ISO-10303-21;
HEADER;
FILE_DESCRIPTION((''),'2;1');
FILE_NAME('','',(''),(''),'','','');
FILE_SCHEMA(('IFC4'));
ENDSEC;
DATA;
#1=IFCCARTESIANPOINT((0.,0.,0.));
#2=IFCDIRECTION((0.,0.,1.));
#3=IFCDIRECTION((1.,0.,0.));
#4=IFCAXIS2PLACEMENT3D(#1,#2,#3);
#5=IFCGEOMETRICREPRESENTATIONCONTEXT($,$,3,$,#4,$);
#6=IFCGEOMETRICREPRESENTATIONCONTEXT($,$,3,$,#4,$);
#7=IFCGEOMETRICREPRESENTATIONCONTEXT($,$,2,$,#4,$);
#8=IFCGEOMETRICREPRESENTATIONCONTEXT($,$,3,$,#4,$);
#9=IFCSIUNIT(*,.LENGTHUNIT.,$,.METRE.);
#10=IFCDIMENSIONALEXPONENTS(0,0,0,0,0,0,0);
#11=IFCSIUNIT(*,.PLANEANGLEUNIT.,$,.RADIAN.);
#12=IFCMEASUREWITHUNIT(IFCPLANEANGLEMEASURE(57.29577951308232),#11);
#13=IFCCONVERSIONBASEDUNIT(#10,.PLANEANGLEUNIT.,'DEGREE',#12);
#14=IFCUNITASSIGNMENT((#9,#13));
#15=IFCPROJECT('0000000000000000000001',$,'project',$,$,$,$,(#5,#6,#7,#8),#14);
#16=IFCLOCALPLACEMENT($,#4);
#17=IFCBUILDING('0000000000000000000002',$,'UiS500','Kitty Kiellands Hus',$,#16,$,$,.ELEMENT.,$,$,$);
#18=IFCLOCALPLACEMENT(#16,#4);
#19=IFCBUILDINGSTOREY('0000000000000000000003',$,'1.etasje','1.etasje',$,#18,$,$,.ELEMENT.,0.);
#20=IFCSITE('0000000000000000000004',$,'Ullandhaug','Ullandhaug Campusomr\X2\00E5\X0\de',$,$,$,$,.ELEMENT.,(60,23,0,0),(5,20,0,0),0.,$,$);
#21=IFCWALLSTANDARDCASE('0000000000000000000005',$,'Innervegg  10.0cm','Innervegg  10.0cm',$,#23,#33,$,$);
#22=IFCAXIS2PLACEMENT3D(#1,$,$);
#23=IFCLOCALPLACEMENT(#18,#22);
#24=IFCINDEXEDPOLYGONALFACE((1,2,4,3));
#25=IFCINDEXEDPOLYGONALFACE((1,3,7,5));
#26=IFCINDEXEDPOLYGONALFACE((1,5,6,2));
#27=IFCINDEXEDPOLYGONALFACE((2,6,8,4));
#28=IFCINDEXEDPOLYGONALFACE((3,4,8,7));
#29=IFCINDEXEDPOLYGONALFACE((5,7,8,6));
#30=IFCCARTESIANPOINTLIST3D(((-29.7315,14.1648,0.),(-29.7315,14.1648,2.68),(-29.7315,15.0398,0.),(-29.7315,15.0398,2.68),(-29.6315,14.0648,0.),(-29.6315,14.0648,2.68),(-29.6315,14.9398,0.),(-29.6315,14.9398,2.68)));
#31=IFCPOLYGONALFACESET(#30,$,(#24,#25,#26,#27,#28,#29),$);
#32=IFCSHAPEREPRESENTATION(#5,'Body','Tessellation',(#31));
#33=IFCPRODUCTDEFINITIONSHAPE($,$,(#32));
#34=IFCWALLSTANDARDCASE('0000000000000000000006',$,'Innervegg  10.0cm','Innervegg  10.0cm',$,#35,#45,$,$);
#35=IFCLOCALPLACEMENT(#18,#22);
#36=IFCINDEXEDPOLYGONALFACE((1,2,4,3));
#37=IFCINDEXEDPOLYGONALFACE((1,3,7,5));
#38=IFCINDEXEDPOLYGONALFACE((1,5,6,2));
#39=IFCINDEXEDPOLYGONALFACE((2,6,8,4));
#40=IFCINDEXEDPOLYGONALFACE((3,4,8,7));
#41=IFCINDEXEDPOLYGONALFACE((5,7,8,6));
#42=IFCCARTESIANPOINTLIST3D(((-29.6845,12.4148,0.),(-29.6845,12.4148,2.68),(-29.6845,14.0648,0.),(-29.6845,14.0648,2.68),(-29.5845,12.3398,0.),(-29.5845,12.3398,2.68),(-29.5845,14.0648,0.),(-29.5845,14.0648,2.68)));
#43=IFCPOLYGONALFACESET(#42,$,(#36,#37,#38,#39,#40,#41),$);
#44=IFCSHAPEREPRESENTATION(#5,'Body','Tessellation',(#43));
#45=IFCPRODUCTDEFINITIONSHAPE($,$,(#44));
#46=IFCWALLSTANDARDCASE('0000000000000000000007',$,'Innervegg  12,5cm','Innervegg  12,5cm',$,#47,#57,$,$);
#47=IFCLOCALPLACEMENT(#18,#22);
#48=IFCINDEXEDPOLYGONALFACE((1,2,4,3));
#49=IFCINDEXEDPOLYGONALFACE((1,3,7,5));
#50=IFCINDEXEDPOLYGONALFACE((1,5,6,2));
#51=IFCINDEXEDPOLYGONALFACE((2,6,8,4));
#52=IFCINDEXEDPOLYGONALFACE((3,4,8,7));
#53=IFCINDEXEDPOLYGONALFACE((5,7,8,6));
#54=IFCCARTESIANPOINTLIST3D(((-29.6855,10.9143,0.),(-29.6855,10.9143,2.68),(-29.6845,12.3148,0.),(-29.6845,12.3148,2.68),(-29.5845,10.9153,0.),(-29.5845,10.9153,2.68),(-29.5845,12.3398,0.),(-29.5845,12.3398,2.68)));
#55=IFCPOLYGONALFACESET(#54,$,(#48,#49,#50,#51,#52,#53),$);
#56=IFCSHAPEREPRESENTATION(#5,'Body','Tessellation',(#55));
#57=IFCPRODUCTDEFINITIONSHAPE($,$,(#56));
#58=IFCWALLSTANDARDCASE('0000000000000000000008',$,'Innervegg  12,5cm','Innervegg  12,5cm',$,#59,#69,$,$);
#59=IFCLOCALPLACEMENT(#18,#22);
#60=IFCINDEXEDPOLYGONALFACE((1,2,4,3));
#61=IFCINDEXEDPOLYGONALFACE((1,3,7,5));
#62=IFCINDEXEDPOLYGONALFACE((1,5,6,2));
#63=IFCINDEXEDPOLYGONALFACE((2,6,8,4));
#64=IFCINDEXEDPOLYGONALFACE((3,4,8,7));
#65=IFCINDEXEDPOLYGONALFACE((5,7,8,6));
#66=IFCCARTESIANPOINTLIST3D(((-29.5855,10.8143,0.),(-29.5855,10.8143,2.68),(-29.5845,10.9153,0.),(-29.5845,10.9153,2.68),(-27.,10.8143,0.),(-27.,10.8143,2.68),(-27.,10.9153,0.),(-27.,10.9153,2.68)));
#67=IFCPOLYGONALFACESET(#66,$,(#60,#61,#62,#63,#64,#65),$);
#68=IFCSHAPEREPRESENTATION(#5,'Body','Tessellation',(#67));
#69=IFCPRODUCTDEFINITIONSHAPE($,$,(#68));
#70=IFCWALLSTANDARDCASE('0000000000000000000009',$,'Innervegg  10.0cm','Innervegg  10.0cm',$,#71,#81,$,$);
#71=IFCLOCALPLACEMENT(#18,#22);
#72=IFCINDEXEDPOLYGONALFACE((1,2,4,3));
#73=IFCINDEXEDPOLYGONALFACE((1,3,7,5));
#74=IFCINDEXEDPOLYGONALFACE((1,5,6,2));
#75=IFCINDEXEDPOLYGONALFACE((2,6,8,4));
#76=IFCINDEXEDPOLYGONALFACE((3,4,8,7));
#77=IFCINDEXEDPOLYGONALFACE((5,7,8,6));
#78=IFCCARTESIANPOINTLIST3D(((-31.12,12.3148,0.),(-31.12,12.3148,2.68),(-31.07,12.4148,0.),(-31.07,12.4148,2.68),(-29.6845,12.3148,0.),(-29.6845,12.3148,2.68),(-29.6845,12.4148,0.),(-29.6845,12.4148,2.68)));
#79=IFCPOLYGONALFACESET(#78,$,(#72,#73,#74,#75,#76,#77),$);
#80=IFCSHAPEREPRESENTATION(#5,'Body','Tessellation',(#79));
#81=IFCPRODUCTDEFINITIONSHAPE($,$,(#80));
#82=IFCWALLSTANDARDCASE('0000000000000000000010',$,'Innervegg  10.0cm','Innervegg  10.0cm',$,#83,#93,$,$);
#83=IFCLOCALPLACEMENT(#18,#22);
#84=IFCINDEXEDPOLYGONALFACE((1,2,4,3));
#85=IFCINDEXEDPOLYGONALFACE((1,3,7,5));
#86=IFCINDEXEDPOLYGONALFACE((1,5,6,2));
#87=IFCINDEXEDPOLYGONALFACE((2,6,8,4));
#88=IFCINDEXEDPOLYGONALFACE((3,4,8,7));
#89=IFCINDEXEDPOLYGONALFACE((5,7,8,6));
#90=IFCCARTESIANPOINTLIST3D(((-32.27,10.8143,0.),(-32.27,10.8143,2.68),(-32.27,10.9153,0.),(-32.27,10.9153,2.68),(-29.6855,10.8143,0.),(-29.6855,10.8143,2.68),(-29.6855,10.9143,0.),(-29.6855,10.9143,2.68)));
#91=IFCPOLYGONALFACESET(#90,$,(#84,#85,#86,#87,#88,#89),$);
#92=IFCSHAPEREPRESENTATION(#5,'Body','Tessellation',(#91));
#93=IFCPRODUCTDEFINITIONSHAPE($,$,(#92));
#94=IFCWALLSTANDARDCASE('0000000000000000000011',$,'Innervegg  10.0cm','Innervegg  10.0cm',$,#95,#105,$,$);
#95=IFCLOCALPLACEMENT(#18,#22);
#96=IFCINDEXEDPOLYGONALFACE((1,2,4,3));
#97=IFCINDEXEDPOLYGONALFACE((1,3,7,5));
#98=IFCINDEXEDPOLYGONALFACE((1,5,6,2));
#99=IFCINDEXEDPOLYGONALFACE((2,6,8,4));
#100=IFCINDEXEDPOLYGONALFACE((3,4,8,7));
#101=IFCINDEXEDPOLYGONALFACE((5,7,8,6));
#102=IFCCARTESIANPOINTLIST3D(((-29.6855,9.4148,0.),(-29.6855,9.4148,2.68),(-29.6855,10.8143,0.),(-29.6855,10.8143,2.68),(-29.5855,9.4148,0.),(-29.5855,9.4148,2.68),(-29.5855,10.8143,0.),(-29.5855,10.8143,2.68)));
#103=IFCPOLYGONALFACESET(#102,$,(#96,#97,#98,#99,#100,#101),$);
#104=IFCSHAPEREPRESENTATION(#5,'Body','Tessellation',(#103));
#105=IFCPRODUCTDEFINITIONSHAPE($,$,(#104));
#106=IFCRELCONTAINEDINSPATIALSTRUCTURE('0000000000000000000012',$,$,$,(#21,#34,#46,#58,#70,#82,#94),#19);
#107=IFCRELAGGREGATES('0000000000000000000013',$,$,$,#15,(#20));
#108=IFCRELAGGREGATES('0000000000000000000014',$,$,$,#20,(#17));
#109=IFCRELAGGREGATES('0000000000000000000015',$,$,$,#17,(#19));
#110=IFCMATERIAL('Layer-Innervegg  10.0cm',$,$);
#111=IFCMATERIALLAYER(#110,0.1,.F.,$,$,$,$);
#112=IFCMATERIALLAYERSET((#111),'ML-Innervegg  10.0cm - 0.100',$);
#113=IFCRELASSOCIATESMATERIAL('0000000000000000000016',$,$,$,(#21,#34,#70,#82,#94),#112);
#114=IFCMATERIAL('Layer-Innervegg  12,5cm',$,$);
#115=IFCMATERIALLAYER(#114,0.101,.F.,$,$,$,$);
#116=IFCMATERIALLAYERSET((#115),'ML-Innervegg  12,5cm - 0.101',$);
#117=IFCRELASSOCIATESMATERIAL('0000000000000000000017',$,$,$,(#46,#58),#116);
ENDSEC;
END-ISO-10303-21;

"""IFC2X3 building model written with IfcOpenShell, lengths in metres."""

from ifc_helpers import new_model, entity, si_unit, converted_unit, frame, origin_with_axes, place, context, project, spatial, polyline, outline, extrude, material, layer, layer_set, layer_usage, element, save


model = new_model("IFC2X3")

# Units and contexts
context_of_model_1 = context(None, 3, world=origin_with_axes())
context_of_model_2 = context(None, 3, world=origin_with_axes())
context_of_model_3 = context(None, 2, world=origin_with_axes())
context_of_model_4 = context(None, 3, world=origin_with_axes())
ifc_project = project(units=[si_unit("LENGTHUNIT", "METRE"), converted_unit("PLANEANGLEUNIT", "DEGREE", entity("IfcPlaneAngleMeasure", 57.29577951308232), si_unit("PLANEANGLEUNIT", "RADIAN"), dimensions=[0, 0, 0, 0, 0, 0, 0])], contexts=[context_of_model_1, context_of_model_2, context_of_model_3, context_of_model_4])

# Site, building, storey
site = spatial("IfcSite", under=ifc_project, Name="Ullandhaug", Description="Ullandhaug Campusområde", CompositionType="ELEMENT", RefLatitude=(60, 23, 0, 0), RefLongitude=(5, 20, 0, 0), RefElevation=0.0)
building_placement = place(None, origin_with_axes())
building = spatial("IfcBuilding", under=site, at=building_placement, Name="UiS500", Description="Kitty Kiellands Hus", CompositionType="ELEMENT")
storey_placement = place(building_placement, origin_with_axes())
storey = spatial("IfcBuildingStorey", under=building, at=storey_placement, Name="1.etasje", Description="1.etasje", CompositionType="ELEMENT", Elevation=0.0)

# Shared definitions
ifc_material_1 = material(Name="Layer-Innervegg  10.0cm")
ifc_layer_1 = layer(ifc_material_1, 0.1, ventilated=False)
ifc_layer_set_1 = layer_set([ifc_layer_1], Name="ML-Innervegg  10.0cm - 0.100")
ifc_layer_usage_1 = layer_usage(ifc_layer_set_1, "AXIS2", "POSITIVE", 0.0)

# Walls
wall_1_placement = place(storey_placement, frame((-29.6315, 14.0648, 0.0), z_axis=(0.0, 0.0, 1.0), x_axis=(0.0, 1.0, 0.0)))
element("IfcWallStandardCase", 1, at=wall_1_placement, inside=storey, material=ifc_layer_usage_1, Name="Innervegg  10.0cm", Description="Innervegg  10.0cm", context=context_of_model_1, shape_type="SweptSolid", body=[
    extrude(outline(polyline([(0.0, 0.0), (0.875, 0.0), (0.975, 0.1), (0.1, 0.1), (0.0, 0.0)])), frame((0.0, 0.0, 0.0), z_axis=(0.0, 0.0, 1.0), x_axis=(1.0, 0.0, 0.0)), (0.0, 0.0, 1.0), 2.68),
])
wall_2_placement = place(storey_placement, frame((-29.6845, 14.0648, 0.0), z_axis=(0.0, 0.0, 1.0), x_axis=(0.0, -1.0, 0.0)))
element("IfcWallStandardCase", 2, at=wall_2_placement, inside=storey, material=ifc_layer_usage_1, Name="Innervegg  10.0cm", Description="Innervegg  10.0cm", context=context_of_model_1, shape_type="SweptSolid", body=[
    extrude(outline(polyline([(0.0, 0.0), (1.65, 0.0), (1.725, 0.1), (0.0, 0.1), (0.0, 0.0)])), frame((0.0, 0.0, 0.0), z_axis=(0.0, 0.0, 1.0), x_axis=(1.0, 0.0, 0.0)), (0.0, 0.0, 1.0), 2.68),
])
ifc_material_2 = material(Name="Layer-Innervegg  12,5cm")
ifc_layer_2 = layer(ifc_material_2, 0.101, ventilated=False)
ifc_layer_set_2 = layer_set([ifc_layer_2], Name="ML-Innervegg  12,5cm - 0.101")
ifc_layer_usage_2 = layer_usage(ifc_layer_set_2, "AXIS2", "POSITIVE", 0.0)
wall_3_placement = place(storey_placement, frame((-29.6845, 12.3148, 0.0), z_axis=(0.0, 0.0, 1.0), x_axis=(-0.000712, -1.0, 0.0)))
element("IfcWallStandardCase", 3, at=wall_3_placement, inside=storey, material=ifc_layer_usage_2, Name="Innervegg  12,5cm", Description="Innervegg  12,5cm", context=context_of_model_1, shape_type="SweptSolid", body=[
    extrude(outline(polyline([(0.0, 0.0), (1.4005, 0.0), (1.3994, 0.101), (-0.0251, 0.1), (0.0, 0.0)])), frame((0.0, 0.0, 0.0), z_axis=(0.0, 0.0, 1.0), x_axis=(1.0, 0.0, 0.0)), (0.0, 0.0, 1.0), 2.68),
])
wall_4_placement = place(storey_placement, frame((-29.5855, 10.8143, 0.0), z_axis=(0.0, 0.0, 1.0), x_axis=(1.0, 0.0, 0.0)))
element("IfcWallStandardCase", 4, at=wall_4_placement, inside=storey, material=ifc_layer_usage_2, Name="Innervegg  12,5cm", Description="Innervegg  12,5cm", context=context_of_model_1, shape_type="SweptSolid", body=[
    extrude(outline(polyline([(0.0, 0.0), (2.5855, 0.0), (2.5855, 0.101), (0.001, 0.101), (0.0, 0.0)])), origin_with_axes(), (0.0, 0.0, 1.0), 2.68),
])
wall_5_placement = place(storey_placement, frame((-31.12, 12.3148, 0.0), z_axis=(0.0, 0.0, 1.0), x_axis=(1.0, 0.0, 0.0)))
element("IfcWallStandardCase", 5, at=wall_5_placement, inside=storey, material=ifc_layer_usage_1, Name="Innervegg  10.0cm", Description="Innervegg  10.0cm", context=context_of_model_1, shape_type="SweptSolid", body=[
    extrude(outline(polyline([(0.0, 0.0), (1.4355, 0.0), (1.4355, 0.1), (0.05, 0.1), (0.0, 0.0)])), origin_with_axes(), (0.0, 0.0, 1.0), 2.68),
])
wall_6_placement = place(storey_placement, frame((-32.27, 10.8143, 0.0), z_axis=(0.0, 0.0, 1.0), x_axis=(1.0, 0.0, 0.0)))
element("IfcWallStandardCase", 6, at=wall_6_placement, inside=storey, material=ifc_layer_usage_1, Name="Innervegg  10.0cm", Description="Innervegg  10.0cm", context=context_of_model_1, shape_type="SweptSolid", body=[
    extrude(outline(polyline([(0.0, 0.0), (2.5845, 0.0), (2.5845, 0.1), (0.0, 0.101), (0.0, 0.0)])), origin_with_axes(), (0.0, 0.0, 1.0), 2.68),
])
wall_7_placement = place(storey_placement, frame((-29.5855, 9.4148, 0.0), z_axis=(0.0, 0.0, 1.0), x_axis=(0.0, 1.0, 0.0)))
element("IfcWallStandardCase", 7, at=wall_7_placement, inside=storey, material=ifc_layer_usage_1, Name="Innervegg  10.0cm", Description="Innervegg  10.0cm", context=context_of_model_1, shape_type="SweptSolid", body=[
    extrude(outline(polyline([(0.0, 0.0), (1.3995, 0.0), (1.3995, 0.1), (0.0, 0.1), (0.0, 0.0)])), frame((0.0, 0.0, 0.0), z_axis=(0.0, 0.0, 1.0), x_axis=(1.0, 0.0, 0.0)), (0.0, 0.0, 1.0), 2.68),
])

save(model, "model.ifc")
